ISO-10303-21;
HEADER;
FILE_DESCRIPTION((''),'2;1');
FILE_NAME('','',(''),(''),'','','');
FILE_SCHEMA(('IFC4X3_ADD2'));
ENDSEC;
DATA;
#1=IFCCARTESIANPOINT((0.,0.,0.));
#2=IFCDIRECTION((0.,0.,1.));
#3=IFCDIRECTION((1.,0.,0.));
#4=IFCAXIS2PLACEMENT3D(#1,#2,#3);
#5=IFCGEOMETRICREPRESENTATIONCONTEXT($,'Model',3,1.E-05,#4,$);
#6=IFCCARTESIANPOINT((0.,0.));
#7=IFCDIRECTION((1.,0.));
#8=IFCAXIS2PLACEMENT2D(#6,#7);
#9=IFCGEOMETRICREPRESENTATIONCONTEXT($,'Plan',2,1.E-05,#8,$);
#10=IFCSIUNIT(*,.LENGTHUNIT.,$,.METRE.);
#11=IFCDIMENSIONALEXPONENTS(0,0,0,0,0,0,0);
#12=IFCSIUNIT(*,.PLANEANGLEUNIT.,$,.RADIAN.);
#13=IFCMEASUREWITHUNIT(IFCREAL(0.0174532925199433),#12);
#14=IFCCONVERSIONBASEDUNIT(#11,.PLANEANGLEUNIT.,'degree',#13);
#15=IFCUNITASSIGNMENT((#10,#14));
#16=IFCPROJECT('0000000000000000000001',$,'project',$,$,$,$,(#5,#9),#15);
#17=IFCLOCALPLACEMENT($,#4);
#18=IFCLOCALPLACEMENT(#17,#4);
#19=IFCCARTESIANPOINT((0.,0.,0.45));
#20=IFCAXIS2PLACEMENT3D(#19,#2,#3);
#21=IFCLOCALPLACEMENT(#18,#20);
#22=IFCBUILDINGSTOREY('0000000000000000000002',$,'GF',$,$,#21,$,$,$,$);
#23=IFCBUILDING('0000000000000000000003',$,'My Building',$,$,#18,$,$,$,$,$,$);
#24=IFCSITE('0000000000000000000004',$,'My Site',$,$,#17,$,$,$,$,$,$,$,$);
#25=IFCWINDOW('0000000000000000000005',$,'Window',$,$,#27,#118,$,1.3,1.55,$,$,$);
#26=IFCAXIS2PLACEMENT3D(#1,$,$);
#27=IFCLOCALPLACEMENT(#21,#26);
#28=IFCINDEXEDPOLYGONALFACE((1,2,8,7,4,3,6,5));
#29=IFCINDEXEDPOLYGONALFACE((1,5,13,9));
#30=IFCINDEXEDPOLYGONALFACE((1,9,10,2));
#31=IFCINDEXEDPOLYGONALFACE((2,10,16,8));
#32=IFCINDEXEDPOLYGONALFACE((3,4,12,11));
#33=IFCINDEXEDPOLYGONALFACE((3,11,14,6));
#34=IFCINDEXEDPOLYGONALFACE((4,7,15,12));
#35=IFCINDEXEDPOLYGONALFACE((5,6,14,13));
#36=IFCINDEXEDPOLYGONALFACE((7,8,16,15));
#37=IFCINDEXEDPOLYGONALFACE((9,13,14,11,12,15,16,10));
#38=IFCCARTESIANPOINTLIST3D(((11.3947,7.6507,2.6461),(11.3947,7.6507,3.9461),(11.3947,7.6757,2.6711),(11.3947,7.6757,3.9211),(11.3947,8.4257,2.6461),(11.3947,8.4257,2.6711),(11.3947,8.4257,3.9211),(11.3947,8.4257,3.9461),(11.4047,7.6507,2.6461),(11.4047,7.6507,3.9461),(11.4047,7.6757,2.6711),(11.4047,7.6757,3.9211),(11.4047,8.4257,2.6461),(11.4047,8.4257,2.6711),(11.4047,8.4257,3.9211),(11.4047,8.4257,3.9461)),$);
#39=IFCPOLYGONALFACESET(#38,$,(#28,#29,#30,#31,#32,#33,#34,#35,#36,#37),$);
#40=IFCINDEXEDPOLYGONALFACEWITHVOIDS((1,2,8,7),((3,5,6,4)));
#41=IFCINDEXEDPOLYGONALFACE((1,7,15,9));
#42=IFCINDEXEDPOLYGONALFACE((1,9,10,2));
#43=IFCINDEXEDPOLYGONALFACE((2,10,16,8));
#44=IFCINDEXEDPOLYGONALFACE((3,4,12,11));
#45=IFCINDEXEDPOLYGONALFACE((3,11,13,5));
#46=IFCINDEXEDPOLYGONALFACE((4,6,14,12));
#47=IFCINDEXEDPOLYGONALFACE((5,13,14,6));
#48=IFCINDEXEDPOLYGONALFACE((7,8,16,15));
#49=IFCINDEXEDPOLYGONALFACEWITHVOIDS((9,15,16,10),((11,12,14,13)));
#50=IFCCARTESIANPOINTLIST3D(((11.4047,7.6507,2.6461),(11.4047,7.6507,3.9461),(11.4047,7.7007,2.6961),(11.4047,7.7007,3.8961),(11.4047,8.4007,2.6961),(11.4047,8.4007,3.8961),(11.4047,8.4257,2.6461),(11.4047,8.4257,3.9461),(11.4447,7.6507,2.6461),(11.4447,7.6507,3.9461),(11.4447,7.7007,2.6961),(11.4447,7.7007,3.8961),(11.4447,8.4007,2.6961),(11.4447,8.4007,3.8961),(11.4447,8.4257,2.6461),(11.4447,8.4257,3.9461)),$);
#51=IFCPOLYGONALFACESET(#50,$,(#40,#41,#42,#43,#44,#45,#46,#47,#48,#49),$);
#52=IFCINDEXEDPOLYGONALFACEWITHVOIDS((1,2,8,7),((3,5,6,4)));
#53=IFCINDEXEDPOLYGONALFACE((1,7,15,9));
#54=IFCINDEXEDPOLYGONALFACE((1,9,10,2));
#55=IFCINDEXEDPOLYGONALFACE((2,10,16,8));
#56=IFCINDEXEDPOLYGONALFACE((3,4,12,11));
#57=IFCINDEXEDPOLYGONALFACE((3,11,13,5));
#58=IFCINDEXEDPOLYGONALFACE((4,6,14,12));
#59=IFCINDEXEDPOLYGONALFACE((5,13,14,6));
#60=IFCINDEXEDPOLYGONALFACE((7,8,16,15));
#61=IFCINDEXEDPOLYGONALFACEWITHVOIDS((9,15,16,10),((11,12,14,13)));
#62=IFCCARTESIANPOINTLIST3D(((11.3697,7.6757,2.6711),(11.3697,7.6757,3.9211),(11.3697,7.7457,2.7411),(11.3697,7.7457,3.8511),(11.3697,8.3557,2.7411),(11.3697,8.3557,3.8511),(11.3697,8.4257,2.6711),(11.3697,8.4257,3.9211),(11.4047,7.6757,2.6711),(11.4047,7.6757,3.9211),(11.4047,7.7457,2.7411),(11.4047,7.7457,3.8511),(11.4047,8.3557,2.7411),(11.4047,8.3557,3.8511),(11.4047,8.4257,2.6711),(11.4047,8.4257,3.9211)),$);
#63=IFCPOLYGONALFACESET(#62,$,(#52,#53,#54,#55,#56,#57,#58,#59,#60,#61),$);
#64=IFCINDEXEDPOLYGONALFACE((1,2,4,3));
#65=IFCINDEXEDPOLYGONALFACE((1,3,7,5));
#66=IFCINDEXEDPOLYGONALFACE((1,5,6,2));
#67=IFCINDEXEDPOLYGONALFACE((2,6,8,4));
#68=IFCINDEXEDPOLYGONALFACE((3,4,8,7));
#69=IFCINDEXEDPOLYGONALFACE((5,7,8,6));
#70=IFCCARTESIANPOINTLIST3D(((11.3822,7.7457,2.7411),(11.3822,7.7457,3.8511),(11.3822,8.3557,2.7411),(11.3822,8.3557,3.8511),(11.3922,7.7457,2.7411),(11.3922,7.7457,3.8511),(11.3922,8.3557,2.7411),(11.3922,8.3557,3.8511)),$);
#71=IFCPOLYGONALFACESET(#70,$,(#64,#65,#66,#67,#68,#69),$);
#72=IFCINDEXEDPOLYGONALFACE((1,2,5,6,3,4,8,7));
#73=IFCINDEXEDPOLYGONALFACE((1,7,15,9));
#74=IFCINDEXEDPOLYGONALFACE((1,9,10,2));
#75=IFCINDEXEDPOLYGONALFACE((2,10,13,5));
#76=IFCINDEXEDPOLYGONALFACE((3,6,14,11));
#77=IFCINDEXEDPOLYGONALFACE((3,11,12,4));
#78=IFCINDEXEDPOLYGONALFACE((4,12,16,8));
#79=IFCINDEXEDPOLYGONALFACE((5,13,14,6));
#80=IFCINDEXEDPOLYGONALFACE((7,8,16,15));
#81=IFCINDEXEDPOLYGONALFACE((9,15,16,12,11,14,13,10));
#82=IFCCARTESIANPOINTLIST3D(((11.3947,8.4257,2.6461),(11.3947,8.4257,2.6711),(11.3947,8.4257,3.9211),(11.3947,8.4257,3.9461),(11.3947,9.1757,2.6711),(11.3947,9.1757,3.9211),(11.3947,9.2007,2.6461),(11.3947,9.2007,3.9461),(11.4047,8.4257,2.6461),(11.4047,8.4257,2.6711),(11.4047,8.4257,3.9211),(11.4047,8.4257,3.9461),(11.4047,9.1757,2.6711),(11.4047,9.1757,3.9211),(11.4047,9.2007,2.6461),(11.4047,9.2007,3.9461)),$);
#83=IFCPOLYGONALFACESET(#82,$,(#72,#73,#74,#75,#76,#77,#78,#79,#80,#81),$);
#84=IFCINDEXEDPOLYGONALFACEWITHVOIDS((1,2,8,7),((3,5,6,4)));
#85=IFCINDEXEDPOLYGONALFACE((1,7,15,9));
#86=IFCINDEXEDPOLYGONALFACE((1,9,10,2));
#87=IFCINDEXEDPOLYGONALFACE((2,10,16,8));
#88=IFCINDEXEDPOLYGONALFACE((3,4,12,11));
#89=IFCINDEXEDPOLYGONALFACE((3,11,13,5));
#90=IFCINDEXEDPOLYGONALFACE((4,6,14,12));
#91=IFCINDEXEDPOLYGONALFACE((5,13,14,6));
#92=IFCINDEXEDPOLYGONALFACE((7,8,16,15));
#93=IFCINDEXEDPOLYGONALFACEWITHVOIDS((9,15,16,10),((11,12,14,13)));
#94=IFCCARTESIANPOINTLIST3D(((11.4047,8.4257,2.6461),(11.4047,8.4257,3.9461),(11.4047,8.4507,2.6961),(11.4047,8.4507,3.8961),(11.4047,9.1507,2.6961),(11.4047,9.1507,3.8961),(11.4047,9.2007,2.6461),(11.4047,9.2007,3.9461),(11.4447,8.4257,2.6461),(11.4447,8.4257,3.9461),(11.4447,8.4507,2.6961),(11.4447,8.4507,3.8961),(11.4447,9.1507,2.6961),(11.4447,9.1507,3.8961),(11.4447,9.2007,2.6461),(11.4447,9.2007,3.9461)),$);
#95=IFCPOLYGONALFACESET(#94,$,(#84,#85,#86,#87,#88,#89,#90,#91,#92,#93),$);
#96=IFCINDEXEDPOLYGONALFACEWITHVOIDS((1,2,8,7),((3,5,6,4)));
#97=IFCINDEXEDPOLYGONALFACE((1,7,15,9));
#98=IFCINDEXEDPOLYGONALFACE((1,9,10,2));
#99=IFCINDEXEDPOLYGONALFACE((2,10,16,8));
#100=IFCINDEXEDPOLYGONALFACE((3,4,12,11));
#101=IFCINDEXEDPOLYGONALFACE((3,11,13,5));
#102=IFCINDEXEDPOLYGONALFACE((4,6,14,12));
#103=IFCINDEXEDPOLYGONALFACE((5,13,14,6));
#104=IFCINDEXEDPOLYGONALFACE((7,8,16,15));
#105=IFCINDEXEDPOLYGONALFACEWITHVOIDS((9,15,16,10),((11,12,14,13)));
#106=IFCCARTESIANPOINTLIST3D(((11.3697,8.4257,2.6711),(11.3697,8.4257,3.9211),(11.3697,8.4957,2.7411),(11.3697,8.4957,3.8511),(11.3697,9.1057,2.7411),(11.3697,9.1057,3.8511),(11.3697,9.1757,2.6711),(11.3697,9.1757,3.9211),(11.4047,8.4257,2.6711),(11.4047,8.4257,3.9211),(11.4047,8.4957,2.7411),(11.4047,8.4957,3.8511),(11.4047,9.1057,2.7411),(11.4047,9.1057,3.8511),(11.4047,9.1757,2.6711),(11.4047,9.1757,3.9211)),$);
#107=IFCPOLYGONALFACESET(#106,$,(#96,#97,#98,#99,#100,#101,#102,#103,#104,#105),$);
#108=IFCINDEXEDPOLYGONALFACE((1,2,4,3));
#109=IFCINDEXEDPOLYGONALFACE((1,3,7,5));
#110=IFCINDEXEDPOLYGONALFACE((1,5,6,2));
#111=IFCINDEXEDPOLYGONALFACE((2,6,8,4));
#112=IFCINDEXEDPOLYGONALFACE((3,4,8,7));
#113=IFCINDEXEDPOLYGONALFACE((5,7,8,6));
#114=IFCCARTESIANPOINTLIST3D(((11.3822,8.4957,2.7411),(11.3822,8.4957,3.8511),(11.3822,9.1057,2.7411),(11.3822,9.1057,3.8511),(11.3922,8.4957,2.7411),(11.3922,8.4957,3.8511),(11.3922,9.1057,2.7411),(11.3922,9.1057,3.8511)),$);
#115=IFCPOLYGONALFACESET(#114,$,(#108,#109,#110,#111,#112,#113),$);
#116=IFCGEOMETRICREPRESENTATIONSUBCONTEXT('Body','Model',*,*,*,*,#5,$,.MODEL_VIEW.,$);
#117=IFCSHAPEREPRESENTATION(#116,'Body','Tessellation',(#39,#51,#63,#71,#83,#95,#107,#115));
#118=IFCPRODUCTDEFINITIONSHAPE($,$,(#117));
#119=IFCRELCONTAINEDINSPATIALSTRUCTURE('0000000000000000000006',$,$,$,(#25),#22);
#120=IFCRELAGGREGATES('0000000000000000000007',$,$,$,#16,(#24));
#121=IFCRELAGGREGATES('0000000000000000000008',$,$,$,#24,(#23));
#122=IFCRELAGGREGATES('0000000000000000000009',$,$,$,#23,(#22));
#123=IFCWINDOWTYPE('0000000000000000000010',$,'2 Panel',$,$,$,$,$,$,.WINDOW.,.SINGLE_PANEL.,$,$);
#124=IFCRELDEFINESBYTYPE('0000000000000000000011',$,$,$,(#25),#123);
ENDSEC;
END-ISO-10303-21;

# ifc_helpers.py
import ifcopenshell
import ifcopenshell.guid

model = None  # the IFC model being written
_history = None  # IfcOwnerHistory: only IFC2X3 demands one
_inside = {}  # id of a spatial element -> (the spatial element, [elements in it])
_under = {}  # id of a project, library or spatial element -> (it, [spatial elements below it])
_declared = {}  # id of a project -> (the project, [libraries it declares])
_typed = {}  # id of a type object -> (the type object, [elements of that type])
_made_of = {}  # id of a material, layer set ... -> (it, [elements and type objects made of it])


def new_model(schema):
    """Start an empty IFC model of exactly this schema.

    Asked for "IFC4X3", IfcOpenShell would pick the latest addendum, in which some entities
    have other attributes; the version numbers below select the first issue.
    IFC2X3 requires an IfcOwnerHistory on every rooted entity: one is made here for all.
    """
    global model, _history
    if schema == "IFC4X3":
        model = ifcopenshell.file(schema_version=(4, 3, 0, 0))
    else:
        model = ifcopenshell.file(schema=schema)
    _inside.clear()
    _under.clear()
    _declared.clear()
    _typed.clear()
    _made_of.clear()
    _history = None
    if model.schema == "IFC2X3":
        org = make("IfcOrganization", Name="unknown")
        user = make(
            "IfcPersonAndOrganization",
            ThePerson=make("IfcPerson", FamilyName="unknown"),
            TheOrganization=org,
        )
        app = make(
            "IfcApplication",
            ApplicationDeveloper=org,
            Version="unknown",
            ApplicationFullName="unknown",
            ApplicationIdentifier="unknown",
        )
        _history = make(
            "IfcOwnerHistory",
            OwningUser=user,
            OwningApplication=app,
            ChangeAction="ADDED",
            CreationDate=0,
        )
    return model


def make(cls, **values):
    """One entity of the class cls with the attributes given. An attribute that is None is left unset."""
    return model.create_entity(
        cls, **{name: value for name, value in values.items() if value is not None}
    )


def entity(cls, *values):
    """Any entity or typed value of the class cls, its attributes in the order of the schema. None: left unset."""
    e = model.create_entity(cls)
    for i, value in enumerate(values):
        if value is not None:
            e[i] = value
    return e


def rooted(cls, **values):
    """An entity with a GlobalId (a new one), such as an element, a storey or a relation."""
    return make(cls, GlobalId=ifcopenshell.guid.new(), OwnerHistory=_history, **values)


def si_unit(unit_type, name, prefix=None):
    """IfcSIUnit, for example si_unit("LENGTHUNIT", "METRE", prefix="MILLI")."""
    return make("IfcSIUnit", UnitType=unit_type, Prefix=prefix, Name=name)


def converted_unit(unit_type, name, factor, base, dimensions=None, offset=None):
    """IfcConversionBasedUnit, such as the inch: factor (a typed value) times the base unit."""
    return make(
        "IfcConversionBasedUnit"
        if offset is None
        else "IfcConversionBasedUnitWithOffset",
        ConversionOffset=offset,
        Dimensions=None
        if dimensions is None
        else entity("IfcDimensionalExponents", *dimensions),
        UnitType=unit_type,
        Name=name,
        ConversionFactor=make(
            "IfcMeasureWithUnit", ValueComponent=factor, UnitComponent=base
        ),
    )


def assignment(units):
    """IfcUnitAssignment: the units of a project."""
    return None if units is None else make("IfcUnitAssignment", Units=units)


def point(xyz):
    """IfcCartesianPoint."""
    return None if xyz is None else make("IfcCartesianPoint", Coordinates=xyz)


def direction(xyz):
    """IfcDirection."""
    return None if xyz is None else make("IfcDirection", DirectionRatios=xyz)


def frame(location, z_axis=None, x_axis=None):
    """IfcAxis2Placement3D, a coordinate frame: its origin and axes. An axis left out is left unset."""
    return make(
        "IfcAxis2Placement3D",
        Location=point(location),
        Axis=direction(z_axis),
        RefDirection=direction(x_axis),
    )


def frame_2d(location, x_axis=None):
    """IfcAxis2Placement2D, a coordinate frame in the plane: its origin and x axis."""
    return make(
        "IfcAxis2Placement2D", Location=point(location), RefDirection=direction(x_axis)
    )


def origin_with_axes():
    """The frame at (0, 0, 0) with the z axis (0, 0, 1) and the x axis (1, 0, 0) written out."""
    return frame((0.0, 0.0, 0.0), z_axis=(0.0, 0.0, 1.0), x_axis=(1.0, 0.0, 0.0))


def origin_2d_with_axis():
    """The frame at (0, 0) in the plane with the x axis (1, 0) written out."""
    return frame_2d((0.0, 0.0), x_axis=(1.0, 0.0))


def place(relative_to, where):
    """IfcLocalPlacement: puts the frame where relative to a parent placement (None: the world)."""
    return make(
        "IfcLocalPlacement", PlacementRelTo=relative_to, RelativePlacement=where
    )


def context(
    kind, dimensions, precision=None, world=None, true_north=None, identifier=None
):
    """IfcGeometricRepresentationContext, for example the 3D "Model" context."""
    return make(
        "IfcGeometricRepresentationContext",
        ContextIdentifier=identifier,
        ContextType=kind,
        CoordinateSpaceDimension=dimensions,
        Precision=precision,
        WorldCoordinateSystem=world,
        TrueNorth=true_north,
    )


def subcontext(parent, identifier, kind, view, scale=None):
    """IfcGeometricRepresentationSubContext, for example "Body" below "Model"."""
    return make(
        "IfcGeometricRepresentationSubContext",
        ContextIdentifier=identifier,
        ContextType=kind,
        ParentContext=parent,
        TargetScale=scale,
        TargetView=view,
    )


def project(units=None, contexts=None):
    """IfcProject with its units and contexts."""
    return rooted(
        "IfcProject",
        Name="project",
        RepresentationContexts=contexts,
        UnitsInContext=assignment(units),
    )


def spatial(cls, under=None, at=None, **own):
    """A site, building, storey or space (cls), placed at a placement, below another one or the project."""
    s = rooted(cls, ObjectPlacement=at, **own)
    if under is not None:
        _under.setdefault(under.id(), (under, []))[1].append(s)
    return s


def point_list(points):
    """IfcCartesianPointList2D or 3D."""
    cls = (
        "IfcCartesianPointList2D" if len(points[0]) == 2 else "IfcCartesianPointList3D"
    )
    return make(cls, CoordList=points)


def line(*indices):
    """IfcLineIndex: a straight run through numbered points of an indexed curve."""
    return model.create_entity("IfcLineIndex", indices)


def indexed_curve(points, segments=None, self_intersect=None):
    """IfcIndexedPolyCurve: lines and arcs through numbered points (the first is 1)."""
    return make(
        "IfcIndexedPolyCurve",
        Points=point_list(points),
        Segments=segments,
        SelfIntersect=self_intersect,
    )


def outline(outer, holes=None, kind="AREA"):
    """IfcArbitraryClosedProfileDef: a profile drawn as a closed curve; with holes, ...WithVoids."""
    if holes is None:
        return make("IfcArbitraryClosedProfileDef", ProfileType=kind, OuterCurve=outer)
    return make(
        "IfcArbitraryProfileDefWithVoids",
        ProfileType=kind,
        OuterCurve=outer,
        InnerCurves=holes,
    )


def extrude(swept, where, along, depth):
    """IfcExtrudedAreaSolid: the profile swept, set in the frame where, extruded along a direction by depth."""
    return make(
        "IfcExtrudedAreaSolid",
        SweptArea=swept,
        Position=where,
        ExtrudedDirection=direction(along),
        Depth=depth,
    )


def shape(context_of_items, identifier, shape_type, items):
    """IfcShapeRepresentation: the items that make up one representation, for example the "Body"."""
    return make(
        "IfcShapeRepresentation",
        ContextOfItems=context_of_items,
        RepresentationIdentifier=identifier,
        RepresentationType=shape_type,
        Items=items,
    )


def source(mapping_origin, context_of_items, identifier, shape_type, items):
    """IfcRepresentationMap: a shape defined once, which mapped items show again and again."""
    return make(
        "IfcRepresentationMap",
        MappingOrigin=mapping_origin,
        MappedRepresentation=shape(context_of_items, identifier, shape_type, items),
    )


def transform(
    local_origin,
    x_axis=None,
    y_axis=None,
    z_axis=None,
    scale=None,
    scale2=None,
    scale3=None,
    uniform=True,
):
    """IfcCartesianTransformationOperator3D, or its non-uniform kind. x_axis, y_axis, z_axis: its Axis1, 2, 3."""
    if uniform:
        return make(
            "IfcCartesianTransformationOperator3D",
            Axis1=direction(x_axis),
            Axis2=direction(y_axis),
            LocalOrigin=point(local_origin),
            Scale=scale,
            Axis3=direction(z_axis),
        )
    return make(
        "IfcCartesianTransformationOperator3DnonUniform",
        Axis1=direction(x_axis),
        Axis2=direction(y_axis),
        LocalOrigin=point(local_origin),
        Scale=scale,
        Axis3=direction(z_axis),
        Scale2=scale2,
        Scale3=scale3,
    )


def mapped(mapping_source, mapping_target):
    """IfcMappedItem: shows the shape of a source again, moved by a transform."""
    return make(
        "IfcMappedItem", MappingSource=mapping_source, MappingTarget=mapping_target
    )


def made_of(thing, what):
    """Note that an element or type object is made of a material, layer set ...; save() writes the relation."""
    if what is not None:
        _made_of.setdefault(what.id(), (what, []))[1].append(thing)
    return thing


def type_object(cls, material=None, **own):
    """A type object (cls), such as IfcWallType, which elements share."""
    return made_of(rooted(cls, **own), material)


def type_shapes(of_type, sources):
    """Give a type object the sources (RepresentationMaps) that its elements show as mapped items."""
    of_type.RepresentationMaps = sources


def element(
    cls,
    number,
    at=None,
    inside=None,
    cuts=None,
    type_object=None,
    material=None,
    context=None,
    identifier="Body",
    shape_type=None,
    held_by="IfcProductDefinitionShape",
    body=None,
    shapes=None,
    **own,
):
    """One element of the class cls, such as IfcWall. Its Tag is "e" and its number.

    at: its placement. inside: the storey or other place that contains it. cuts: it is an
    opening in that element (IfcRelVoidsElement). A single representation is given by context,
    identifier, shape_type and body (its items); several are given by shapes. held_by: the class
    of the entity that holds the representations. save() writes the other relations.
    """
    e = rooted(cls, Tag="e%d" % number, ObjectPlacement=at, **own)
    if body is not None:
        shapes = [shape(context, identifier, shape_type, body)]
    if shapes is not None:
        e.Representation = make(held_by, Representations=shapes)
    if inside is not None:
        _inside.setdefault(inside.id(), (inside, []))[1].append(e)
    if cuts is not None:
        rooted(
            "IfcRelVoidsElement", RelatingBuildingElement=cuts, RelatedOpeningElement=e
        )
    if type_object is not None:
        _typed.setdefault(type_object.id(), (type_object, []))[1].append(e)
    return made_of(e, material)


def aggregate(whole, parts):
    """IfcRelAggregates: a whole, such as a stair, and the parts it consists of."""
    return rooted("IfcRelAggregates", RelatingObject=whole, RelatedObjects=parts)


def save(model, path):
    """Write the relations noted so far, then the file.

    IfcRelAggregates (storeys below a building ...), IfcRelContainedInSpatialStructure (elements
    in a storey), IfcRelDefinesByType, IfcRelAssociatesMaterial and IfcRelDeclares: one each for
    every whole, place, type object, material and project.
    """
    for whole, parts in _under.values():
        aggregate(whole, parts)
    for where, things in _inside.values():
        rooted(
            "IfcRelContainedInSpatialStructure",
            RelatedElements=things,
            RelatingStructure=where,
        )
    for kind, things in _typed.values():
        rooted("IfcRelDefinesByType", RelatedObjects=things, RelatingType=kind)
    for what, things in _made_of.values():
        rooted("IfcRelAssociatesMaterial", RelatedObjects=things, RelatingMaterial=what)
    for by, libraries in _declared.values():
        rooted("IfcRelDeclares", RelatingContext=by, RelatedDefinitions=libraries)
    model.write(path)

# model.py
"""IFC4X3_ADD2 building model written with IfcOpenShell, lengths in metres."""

from ifc_helpers import new_model, entity, si_unit, converted_unit, frame, origin_with_axes, origin_2d_with_axis, place, context, subcontext, project, spatial, line, indexed_curve, outline, extrude, shape, source, transform, mapped, type_object, type_shapes, element, save


model = new_model("IFC4X3_ADD2")

# Units and contexts
model_context = context("Model", 3, precision=1e-05, world=origin_with_axes())
plan_context = context("Plan", 2, precision=1e-05, world=origin_2d_with_axis())
body_context_1 = subcontext(model_context, "Body", "Model", "MODEL_VIEW")
body_context_2 = subcontext(plan_context, "Body", "Plan", "PLAN_VIEW")
ifc_project = project(units=[si_unit("LENGTHUNIT", "METRE"), converted_unit("PLANEANGLEUNIT", "degree", entity("IfcReal", 0.0174532925199433), si_unit("PLANEANGLEUNIT", "RADIAN"), dimensions=[0, 0, 0, 0, 0, 0, 0])], contexts=[model_context, plan_context])

# Site, building, storey
site_placement = place(None, origin_with_axes())
site = spatial("IfcSite", under=ifc_project, at=site_placement, Name="My Site")
building_placement = place(site_placement, origin_with_axes())
building = spatial("IfcBuilding", under=site, at=building_placement, Name="My Building")
storey_placement = place(building_placement, frame((0.0, 0.0, 0.45), z_axis=(0.0, 0.0, 1.0), x_axis=(1.0, 0.0, 0.0)))
storey = spatial("IfcBuildingStorey", under=building, at=storey_placement, Name="GF")

# Shared definitions
wall_placement = place(storey_placement, frame((11.4947, 2.9876, 0.0), z_axis=(0.0, 0.0, 1.0), x_axis=(0.0, 1.0, 0.0)))
window_type = type_object("IfcWindowType", Name="2 Panel", PartitioningType="SINGLE_PANEL", PredefinedType="WINDOW")
shared_shape_1 = source(origin_with_axes(), body_context_1, "Body", "SweptSolid", [
    extrude(outline(indexed_curve([(0.775, 0.0), (0.0, 0.0), (0.0, 1.3), (0.775, 1.3), (0.775, 1.275), (0.025, 1.275), (0.025, 0.025), (0.775, 0.025)], segments=[line(1, 2, 3, 4, 5, 6, 7, 8, 1)])), frame((0.0, 0.09, 0.0), z_axis=(0.0, -1.0, 0.0), x_axis=(1.0, 0.0, 0.0)), (0.0, 0.0, -1.0), 0.01),
    extrude(outline(indexed_curve([(0.0, 0.0), (0.775, 0.0), (0.775, 1.3), (0.0, 1.3)], segments=[line(1, 2, 3, 4, 1)]), holes=[indexed_curve([(0.05, 0.05), (0.75, 0.05), (0.75, 1.25), (0.05, 1.25)], segments=[line(1, 2, 3, 4, 1)])]), frame((0.0, 0.05, 0.0), z_axis=(0.0, -1.0, 0.0), x_axis=(1.0, 0.0, 0.0)), (0.0, 0.0, -1.0), 0.04),
    extrude(outline(indexed_curve([(0.0, 0.0), (0.75, 0.0), (0.75, 1.25), (0.0, 1.25)], segments=[line(1, 2, 3, 4, 1)]), holes=[indexed_curve([(0.07, 0.07), (0.68, 0.07), (0.68, 1.18), (0.07, 1.18)], segments=[line(1, 2, 3, 4, 1)])]), frame((0.025, 0.09, 0.025), z_axis=(0.0, -1.0, 0.0), x_axis=(1.0, 0.0, 0.0)), (0.0, 0.0, -1.0), 0.035),
    extrude(outline(indexed_curve([(0.07, 0.07), (0.68, 0.07), (0.68, 1.18), (0.07, 1.18)], segments=[line(1, 2, 3, 4, 1)])), frame((0.025, 0.1025, 0.025), z_axis=(0.0, -1.0, 0.0), x_axis=(1.0, 0.0, 0.0)), (0.0, 0.0, -1.0), 0.01),
    extrude(outline(indexed_curve([(0.0, 1.3), (0.775, 1.3), (0.775, 0.0), (0.0, 0.0), (0.0, 0.025), (0.75, 0.025), (0.75, 1.275), (0.0, 1.275)], segments=[line(1, 2, 3, 4, 5, 6, 7, 8, 1)])), frame((0.775, 0.09, 0.0), z_axis=(0.0, -1.0, 0.0), x_axis=(1.0, 0.0, 0.0)), (0.0, 0.0, -1.0), 0.01),
    extrude(outline(indexed_curve([(0.0, 0.0), (0.775, 0.0), (0.775, 1.3), (0.0, 1.3)], segments=[line(1, 2, 3, 4, 1)]), holes=[indexed_curve([(0.025, 0.05), (0.725, 0.05), (0.725, 1.25), (0.025, 1.25)], segments=[line(1, 2, 3, 4, 1)])]), frame((0.775, 0.05, 0.0), z_axis=(0.0, -1.0, 0.0), x_axis=(1.0, 0.0, 0.0)), (0.0, 0.0, -1.0), 0.04),
    extrude(outline(indexed_curve([(0.0, 0.0), (0.75, 0.0), (0.75, 1.25), (0.0, 1.25)], segments=[line(1, 2, 3, 4, 1)]), holes=[indexed_curve([(0.07, 0.07), (0.68, 0.07), (0.68, 1.18), (0.07, 1.18)], segments=[line(1, 2, 3, 4, 1)])]), frame((0.775, 0.09, 0.025), z_axis=(0.0, -1.0, 0.0), x_axis=(1.0, 0.0, 0.0)), (0.0, 0.0, -1.0), 0.035),
    extrude(outline(indexed_curve([(0.07, 0.07), (0.68, 0.07), (0.68, 1.18), (0.07, 1.18)], segments=[line(1, 2, 3, 4, 1)])), frame((0.775, 0.1025, 0.025), z_axis=(0.0, -1.0, 0.0), x_axis=(1.0, 0.0, 0.0)), (0.0, 0.0, -1.0), 0.01),
])
shared_shape_2 = source(origin_with_axes(), body_context_2, "Body", "Curve2D", [
    entity("IfcIndexedPolyCurve", entity("IfcCartesianPointList2D", [[0.05, 0.05], [0.75, 0.05]])),
    entity("IfcIndexedPolyCurve", entity("IfcCartesianPointList2D", [[0.0, 0.1], [0.025, 0.1], [0.025, 0.09], [0.05, 0.09], [0.05, 0.05], [0.0, 0.05]]), [entity("IfcLineIndex", [1, 2, 3, 4, 5, 6, 1])]),
    entity("IfcIndexedPolyCurve", entity("IfcCartesianPointList2D", [[0.775, 0.1], [0.775, 0.1], [0.775, 0.09], [0.75, 0.09], [0.75, 0.05], [0.775, 0.05]])),
    entity("IfcIndexedPolyCurve", entity("IfcCartesianPointList2D", [[0.025, 0.09], [0.095, 0.09], [0.095, 0.125], [0.025, 0.125]]), [entity("IfcLineIndex", [1, 2, 3, 4, 1])]),
    entity("IfcIndexedPolyCurve", entity("IfcCartesianPointList2D", [[0.775, 0.09], [0.705, 0.09], [0.705, 0.125], [0.775, 0.125]]), [entity("IfcLineIndex", [1, 2, 3, 4, 1])]),
    entity("IfcIndexedPolyCurve", entity("IfcCartesianPointList2D", [[0.095, 0.09], [0.705, 0.09]])),
    entity("IfcIndexedPolyCurve", entity("IfcCartesianPointList2D", [[0.095, 0.125], [0.705, 0.125]])),
    entity("IfcIndexedPolyCurve", entity("IfcCartesianPointList2D", [[0.095, 0.1075], [0.705, 0.1075]])),
    entity("IfcIndexedPolyCurve", entity("IfcCartesianPointList2D", [[0.8, 0.05], [1.5, 0.05]])),
    entity("IfcIndexedPolyCurve", entity("IfcCartesianPointList2D", [[0.775, 0.1], [0.775, 0.1], [0.775, 0.09], [0.8, 0.09], [0.8, 0.05], [0.775, 0.05]])),
    entity("IfcIndexedPolyCurve", entity("IfcCartesianPointList2D", [[1.55, 0.1], [1.525, 0.1], [1.525, 0.09], [1.5, 0.09], [1.5, 0.05], [1.55, 0.05]]), [entity("IfcLineIndex", [1, 2, 3, 4, 5, 6, 1])]),
    entity("IfcIndexedPolyCurve", entity("IfcCartesianPointList2D", [[0.775, 0.09], [0.845, 0.09], [0.845, 0.125], [0.775, 0.125]]), [entity("IfcLineIndex", [1, 2, 3, 4, 1])]),
    entity("IfcIndexedPolyCurve", entity("IfcCartesianPointList2D", [[1.525, 0.09], [1.455, 0.09], [1.455, 0.125], [1.525, 0.125]]), [entity("IfcLineIndex", [1, 2, 3, 4, 1])]),
    entity("IfcIndexedPolyCurve", entity("IfcCartesianPointList2D", [[0.845, 0.09], [1.455, 0.09]])),
    entity("IfcIndexedPolyCurve", entity("IfcCartesianPointList2D", [[0.845, 0.125], [1.455, 0.125]])),
    entity("IfcIndexedPolyCurve", entity("IfcCartesianPointList2D", [[0.845, 0.1075], [1.455, 0.1075]])),
])
type_shapes(window_type, [shared_shape_1, shared_shape_2])

# Window
placement = place(wall_placement, frame((4.6632, 0.0, 1.0), z_axis=(0.0, 0.0, 1.0), x_axis=(1.0, 0.0, 0.0)))
window_1_placement = place(placement, frame((0.0, 0.0, 1.6461), z_axis=(0.0, 0.0, 1.0), x_axis=(1.0, 0.0, 0.0)))
element("IfcWindow", 1, at=window_1_placement, inside=storey, type_object=window_type, Name="Window", OverallHeight=1.3, OverallWidth=1.55, shapes=[
    shape(body_context_1, "Body", "MappedRepresentation", [mapped(shared_shape_1, transform((0.0, 0.0, 0.0), x_axis=(1.0, 0.0, 0.0), y_axis=(0.0, 1.0, 0.0), z_axis=(0.0, 0.0, 1.0), scale=1.0))]),
    shape(body_context_2, "Body", "MappedRepresentation", [mapped(shared_shape_2, transform((0.0, 0.0, 0.0), x_axis=(1.0, 0.0, 0.0), y_axis=(0.0, 1.0, 0.0), z_axis=(0.0, 0.0, 1.0), scale=1.0))]),
])

save(model, "model.ifc")
